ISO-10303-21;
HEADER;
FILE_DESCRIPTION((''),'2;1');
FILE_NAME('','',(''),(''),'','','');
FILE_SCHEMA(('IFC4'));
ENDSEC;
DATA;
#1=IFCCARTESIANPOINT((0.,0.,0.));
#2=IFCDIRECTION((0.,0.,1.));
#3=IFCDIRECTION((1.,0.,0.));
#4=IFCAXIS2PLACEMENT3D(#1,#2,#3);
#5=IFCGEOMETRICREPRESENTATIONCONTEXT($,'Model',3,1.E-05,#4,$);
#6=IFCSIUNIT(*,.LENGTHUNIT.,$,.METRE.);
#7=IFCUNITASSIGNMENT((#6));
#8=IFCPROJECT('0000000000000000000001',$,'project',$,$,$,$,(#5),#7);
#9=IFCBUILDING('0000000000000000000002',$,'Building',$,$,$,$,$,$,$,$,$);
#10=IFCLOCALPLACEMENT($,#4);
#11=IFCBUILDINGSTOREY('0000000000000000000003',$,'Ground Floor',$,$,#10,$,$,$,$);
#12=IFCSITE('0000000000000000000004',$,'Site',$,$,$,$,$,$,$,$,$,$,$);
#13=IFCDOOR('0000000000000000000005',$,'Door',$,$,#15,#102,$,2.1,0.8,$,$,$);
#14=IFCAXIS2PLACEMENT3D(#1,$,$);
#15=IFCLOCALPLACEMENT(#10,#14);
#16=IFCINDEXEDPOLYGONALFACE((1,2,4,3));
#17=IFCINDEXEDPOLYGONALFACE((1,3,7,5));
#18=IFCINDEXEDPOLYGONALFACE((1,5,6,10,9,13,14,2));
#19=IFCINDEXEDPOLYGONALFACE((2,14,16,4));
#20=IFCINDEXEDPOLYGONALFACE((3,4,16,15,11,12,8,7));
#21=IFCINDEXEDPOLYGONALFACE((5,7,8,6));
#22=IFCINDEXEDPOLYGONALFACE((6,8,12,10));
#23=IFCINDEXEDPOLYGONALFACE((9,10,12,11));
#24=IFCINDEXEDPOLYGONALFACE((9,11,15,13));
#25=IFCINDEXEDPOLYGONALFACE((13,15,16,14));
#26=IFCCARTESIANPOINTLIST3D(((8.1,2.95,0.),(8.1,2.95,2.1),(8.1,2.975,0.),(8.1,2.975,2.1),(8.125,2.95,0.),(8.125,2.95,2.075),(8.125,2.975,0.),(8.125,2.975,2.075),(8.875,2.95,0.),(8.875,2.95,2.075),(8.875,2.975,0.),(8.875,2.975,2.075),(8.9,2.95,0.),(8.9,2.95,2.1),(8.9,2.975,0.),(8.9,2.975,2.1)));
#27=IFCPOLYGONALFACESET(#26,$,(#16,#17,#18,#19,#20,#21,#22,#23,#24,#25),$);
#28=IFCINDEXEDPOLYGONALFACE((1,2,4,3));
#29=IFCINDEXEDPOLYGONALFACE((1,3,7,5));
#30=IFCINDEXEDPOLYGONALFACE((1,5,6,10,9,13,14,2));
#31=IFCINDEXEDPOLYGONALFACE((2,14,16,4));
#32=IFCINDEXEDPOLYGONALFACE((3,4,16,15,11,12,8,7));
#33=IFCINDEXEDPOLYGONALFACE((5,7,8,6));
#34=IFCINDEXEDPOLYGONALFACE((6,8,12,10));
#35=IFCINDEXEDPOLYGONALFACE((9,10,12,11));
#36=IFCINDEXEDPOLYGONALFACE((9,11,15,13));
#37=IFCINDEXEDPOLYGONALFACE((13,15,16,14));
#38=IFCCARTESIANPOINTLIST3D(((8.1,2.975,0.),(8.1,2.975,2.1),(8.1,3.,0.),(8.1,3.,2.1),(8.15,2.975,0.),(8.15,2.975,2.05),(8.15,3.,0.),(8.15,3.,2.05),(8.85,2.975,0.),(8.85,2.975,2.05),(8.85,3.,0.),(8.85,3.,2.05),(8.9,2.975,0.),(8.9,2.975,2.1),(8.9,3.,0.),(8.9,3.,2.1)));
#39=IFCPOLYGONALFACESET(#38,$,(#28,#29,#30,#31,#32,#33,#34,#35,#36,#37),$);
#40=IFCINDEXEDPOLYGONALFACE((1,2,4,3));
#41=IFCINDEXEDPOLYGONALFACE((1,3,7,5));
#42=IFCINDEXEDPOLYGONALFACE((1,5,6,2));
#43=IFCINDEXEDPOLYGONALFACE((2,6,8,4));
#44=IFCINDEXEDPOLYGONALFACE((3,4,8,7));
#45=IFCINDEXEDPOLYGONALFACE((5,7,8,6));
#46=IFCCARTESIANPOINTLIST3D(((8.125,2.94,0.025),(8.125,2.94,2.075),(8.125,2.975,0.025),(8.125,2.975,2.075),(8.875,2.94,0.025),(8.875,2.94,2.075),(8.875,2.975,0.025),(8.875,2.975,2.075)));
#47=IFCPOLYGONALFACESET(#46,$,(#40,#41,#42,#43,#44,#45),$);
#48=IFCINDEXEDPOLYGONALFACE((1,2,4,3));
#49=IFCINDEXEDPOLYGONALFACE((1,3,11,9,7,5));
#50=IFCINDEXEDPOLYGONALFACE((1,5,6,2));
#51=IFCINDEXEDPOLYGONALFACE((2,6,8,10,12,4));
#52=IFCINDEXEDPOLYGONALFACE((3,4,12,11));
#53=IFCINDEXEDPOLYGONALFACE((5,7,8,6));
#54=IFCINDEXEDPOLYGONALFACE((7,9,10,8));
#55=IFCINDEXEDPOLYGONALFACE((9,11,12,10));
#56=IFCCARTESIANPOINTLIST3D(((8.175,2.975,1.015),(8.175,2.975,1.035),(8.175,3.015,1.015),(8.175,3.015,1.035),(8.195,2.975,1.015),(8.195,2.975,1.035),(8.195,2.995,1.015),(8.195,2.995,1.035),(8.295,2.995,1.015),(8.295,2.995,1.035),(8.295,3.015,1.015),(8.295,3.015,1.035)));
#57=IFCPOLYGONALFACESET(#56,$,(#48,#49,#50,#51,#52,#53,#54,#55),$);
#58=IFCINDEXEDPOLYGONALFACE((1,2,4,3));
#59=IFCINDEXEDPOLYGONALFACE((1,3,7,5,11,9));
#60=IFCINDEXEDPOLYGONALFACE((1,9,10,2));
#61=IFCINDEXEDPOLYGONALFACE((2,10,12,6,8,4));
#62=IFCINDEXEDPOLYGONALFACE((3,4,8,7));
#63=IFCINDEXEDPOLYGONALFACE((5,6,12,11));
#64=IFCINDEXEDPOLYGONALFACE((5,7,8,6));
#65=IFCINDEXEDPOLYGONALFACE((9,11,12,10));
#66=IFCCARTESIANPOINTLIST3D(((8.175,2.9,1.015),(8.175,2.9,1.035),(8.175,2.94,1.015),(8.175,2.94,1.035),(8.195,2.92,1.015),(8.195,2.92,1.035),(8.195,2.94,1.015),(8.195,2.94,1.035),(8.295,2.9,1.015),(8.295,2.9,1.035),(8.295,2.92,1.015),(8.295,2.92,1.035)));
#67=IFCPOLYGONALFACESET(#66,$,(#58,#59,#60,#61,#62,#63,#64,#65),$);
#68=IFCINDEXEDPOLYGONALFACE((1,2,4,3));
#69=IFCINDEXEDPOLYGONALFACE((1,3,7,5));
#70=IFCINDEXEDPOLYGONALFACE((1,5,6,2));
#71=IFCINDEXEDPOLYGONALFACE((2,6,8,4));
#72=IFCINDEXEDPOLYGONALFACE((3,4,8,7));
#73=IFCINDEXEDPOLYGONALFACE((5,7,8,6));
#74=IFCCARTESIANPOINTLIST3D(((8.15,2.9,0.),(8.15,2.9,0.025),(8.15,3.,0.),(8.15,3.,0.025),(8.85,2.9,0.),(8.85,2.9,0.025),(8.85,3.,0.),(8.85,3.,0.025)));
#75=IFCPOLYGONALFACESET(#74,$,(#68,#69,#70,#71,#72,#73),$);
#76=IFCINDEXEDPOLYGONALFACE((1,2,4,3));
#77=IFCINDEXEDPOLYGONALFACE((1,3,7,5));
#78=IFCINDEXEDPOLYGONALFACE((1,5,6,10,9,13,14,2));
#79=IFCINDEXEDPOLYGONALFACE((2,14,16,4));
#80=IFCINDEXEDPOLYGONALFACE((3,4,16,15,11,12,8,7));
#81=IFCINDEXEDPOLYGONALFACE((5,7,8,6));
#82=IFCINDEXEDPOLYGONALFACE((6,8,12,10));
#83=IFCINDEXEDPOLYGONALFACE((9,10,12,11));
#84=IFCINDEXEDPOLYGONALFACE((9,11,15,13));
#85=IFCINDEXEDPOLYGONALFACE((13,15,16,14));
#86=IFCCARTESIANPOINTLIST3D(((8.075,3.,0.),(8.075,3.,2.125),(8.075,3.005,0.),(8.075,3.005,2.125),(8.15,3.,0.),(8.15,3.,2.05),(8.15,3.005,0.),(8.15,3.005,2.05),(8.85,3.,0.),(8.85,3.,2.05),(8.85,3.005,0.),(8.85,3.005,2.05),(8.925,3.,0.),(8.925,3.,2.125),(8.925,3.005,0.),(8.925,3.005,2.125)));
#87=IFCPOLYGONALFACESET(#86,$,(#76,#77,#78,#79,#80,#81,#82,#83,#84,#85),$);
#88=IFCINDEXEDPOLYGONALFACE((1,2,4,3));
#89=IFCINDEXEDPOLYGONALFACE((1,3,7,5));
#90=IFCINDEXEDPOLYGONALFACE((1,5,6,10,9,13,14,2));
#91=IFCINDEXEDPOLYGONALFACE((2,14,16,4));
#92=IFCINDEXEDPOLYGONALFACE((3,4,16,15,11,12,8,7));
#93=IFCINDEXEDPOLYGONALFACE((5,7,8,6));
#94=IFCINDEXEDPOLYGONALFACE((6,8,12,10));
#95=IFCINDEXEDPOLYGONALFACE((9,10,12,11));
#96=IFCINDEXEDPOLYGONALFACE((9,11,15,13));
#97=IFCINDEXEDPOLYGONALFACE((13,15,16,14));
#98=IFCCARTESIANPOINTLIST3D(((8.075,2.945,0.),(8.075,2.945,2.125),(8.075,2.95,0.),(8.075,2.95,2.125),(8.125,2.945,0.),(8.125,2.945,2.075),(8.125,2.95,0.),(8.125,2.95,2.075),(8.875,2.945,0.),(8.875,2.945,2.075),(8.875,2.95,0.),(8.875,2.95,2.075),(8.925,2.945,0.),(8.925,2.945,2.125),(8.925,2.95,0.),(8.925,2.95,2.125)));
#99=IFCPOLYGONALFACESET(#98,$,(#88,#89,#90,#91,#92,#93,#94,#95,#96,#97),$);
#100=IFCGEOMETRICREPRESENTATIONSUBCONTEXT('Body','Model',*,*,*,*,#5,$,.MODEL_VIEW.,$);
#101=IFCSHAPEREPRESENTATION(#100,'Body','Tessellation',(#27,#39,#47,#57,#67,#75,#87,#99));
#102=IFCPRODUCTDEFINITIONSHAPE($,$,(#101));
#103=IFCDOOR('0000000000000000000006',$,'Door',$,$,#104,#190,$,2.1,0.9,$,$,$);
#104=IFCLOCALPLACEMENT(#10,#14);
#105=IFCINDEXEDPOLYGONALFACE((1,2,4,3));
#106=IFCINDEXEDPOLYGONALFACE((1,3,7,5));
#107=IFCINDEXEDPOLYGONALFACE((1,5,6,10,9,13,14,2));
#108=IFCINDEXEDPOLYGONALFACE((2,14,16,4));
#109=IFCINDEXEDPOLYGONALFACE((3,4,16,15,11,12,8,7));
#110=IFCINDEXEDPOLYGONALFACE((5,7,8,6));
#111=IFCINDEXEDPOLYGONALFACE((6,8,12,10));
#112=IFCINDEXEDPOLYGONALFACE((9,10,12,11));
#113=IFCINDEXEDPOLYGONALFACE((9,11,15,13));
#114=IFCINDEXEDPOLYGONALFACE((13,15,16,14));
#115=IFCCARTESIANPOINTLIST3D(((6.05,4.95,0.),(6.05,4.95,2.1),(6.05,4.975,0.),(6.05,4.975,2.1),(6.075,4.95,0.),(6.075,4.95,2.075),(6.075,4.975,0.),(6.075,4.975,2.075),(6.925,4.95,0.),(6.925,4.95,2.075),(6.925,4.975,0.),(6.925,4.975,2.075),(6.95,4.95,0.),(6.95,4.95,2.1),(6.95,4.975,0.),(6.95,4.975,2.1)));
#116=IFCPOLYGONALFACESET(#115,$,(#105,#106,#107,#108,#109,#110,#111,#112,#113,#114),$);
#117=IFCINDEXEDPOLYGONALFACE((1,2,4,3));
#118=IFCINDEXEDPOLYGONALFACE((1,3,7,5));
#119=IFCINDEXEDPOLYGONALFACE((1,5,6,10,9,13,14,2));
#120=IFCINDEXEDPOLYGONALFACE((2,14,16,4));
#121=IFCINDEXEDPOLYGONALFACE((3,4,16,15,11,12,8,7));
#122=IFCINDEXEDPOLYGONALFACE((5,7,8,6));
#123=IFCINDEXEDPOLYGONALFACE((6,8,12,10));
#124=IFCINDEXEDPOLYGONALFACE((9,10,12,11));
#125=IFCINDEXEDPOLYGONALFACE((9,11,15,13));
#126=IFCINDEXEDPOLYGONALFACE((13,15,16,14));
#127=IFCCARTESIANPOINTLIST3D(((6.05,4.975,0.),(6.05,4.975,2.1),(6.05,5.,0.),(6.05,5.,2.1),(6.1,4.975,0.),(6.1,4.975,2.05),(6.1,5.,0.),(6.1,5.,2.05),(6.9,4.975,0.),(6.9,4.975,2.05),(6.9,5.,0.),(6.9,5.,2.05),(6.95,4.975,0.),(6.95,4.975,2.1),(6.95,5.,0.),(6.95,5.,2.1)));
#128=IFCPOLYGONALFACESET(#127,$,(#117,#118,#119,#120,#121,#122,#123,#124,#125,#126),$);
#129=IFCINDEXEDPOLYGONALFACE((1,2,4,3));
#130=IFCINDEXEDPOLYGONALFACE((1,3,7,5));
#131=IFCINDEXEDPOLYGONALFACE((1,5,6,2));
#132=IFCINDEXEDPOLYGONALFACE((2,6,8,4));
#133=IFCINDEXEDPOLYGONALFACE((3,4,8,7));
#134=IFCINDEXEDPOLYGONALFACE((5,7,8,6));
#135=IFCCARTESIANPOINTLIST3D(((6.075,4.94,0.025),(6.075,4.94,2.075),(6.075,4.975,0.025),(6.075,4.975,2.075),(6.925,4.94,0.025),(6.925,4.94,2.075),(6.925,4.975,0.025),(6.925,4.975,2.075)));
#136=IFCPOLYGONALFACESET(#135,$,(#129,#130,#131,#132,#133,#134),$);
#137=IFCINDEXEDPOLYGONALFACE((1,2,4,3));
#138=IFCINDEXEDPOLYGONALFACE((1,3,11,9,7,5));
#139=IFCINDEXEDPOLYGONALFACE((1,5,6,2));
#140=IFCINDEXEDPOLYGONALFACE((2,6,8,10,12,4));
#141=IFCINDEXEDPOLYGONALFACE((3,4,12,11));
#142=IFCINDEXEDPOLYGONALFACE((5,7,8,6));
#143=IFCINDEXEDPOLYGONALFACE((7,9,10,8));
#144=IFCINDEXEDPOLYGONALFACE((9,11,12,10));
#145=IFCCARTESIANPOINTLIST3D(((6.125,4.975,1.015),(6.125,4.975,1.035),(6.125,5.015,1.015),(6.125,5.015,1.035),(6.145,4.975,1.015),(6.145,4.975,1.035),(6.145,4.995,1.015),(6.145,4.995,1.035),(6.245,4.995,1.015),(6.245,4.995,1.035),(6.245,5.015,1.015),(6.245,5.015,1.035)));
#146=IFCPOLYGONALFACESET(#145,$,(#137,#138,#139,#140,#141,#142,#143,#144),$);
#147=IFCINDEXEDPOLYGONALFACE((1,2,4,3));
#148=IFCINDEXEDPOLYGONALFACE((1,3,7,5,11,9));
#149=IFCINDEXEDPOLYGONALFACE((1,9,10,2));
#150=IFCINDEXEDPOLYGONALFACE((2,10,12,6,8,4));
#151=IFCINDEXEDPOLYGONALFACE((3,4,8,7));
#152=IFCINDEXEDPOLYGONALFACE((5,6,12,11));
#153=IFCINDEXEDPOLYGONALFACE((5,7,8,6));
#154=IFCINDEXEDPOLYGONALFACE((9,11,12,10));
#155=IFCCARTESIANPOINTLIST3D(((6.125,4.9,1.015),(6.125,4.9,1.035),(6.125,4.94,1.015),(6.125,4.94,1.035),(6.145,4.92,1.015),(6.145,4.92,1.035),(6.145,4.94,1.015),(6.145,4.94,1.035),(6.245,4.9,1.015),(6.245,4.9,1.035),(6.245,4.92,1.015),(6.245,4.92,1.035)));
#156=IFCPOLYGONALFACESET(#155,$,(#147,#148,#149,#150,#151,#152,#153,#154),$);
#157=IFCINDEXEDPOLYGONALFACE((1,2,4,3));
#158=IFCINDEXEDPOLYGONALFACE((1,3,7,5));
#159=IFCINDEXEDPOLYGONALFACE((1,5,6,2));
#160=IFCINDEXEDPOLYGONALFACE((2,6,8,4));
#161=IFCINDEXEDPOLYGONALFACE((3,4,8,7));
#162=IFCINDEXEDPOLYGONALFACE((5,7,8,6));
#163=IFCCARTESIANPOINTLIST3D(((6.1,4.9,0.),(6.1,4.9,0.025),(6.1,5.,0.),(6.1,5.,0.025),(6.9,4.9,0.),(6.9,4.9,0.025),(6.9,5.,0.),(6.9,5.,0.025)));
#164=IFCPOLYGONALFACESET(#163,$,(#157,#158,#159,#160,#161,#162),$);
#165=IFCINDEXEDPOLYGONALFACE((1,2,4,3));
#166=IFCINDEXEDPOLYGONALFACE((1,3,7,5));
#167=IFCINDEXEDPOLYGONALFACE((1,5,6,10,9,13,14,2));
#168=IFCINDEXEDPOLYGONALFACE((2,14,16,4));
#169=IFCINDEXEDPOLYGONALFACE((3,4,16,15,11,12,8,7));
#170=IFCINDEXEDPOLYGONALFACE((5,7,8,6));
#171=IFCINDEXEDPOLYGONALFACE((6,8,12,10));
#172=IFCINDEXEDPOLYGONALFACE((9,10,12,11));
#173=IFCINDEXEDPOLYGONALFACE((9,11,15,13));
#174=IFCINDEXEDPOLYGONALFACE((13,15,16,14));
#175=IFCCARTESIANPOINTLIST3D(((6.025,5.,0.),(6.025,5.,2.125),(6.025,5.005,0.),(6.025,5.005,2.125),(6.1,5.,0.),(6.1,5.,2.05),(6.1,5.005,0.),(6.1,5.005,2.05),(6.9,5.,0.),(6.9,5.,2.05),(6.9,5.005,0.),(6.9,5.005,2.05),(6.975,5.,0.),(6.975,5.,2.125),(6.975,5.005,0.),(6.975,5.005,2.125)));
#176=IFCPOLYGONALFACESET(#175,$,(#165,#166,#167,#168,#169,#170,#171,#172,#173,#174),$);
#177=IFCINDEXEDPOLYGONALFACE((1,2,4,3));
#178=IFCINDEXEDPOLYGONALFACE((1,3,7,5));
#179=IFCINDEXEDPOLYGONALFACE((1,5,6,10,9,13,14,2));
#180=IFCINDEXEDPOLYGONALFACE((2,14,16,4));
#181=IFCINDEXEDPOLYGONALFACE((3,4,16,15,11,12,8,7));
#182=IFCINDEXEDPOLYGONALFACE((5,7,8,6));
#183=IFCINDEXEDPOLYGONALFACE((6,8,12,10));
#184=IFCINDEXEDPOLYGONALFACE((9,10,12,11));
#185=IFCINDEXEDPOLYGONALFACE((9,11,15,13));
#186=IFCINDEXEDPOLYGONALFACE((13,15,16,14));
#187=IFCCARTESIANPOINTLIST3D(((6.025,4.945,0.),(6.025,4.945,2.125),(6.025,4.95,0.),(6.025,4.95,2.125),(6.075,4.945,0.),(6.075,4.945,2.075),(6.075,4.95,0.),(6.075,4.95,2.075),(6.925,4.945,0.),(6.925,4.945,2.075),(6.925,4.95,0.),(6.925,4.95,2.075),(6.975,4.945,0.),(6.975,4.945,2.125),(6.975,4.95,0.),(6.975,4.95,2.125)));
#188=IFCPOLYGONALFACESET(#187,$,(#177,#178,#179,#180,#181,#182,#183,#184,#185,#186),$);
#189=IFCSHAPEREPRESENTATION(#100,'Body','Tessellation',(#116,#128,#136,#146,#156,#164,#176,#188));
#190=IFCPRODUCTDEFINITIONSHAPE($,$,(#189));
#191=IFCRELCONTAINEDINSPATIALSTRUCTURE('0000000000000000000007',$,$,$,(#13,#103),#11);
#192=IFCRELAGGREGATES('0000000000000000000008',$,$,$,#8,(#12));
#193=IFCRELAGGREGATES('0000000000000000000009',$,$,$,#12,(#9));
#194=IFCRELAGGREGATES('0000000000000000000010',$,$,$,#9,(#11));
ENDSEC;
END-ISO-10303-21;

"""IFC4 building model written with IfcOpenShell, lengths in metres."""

from ifc_helpers import new_model, si_unit, frame, origin_with_axes, place, context, subcontext, project, spatial, line, indexed_curve, outline, extrude, element, save


model = new_model("IFC4")

# Units and contexts
model_context = context("Model", 3, precision=1e-05, world=origin_with_axes())
body_context = subcontext(model_context, "Body", "Model", "MODEL_VIEW")
ifc_project = project(units=[si_unit("LENGTHUNIT", "METRE")], contexts=[model_context])

# Site, building, storey
site = spatial("IfcSite", under=ifc_project, Name="Site")
building = spatial("IfcBuilding", under=site, Name="Building")
storey_placement = place(None, origin_with_axes())
storey = spatial("IfcBuildingStorey", under=building, at=storey_placement, Name="Ground Floor")

# Doors
door_1_placement = place(storey_placement, frame((8.9, 3.0, 0.0), z_axis=(0.0, 0.0, 1.0), x_axis=(-1.0, 0.0, 0.0)))
element("IfcDoor", 1, at=door_1_placement, inside=storey, Name="Door", OverallHeight=2.1, OverallWidth=0.8, context=body_context, shape_type="SweptSolid", body=[
    extrude(outline(indexed_curve([(0.0, 0.0), (0.0, 2.1), (0.8, 2.1), (0.8, 0.0), (0.775, 0.0), (0.775, 2.075), (0.025, 2.075), (0.025, 0.0)], segments=[line(1, 2, 3, 4, 5, 6, 7, 8, 1)])), frame((0.0, 0.025, 0.0), z_axis=(0.0, -1.0, 0.0), x_axis=(1.0, 0.0, 0.0)), (0.0, 0.0, -1.0), 0.025),
    extrude(outline(indexed_curve([(0.0, 0.0), (0.0, 2.1), (0.8, 2.1), (0.8, 0.0), (0.75, 0.0), (0.75, 2.05), (0.05, 2.05), (0.05, 0.0)], segments=[line(1, 2, 3, 4, 5, 6, 7, 8, 1)])), frame((0.0, 0.0, 0.0), z_axis=(0.0, -1.0, 0.0), x_axis=(1.0, 0.0, 0.0)), (0.0, 0.0, -1.0), 0.025),
    extrude(outline(indexed_curve([(0.0, 0.0), (0.75, 0.0), (0.75, 0.035), (0.0, 0.035)], segments=[line(1, 2, 3, 4, 1)])), frame((0.025, 0.025, 0.025), z_axis=(0.0, 0.0, 1.0), x_axis=(1.0, 0.0, 0.0)), (0.0, 0.0, 1.0), 2.05),
    extrude(outline(indexed_curve([(0.0, 0.0), (0.0, -0.04), (-0.12, -0.04), (-0.12, -0.02), (-0.02, -0.02), (-0.02, 0.0)], segments=[line(1, 2, 3, 4, 5, 6, 1)])), frame((0.725, 0.025, 1.015), z_axis=(0.0, 0.0, 1.0), x_axis=(1.0, 0.0, 0.0)), (0.0, 0.0, 1.0), 0.02),
    extrude(outline(indexed_curve([(0.0, 0.0), (0.0, 0.04), (-0.12, 0.04), (-0.12, 0.02), (-0.02, 0.02), (-0.02, 0.0)], segments=[line(1, 2, 3, 4, 5, 6, 1)])), frame((0.725, 0.06, 1.015), z_axis=(0.0, 0.0, 1.0), x_axis=(1.0, 0.0, 0.0)), (0.0, 0.0, 1.0), 0.02),
    extrude(outline(indexed_curve([(0.0, 0.0), (0.7, 0.0), (0.7, 0.1), (0.0, 0.1)], segments=[line(1, 2, 3, 4, 1)])), frame((0.05, 0.0, 0.0), z_axis=(0.0, 0.0, 1.0), x_axis=(1.0, 0.0, 0.0)), (0.0, 0.0, 1.0), 0.025),
    extrude(outline(indexed_curve([(0.0, 0.0), (0.0, 2.125), (0.85, 2.125), (0.85, 0.0), (0.775, 0.0), (0.775, 2.05), (0.075, 2.05), (0.075, 0.0)], segments=[line(1, 2, 3, 4, 5, 6, 7, 8, 1)])), frame((-0.025, -0.005, 0.0), z_axis=(0.0, -1.0, 0.0), x_axis=(1.0, 0.0, 0.0)), (0.0, 0.0, -1.0), 0.005),
    extrude(outline(indexed_curve([(0.0, 0.0), (0.0, 2.125), (0.85, 2.125), (0.85, 0.0), (0.8, 0.0), (0.8, 2.075), (0.05, 2.075), (0.05, 0.0)], segments=[line(1, 2, 3, 4, 5, 6, 7, 8, 1)])), frame((-0.025, 0.05, 0.0), z_axis=(0.0, -1.0, 0.0), x_axis=(1.0, 0.0, 0.0)), (0.0, 0.0, -1.0), 0.005),
])
door_2_placement = place(storey_placement, frame((6.95, 5.0, 0.0), z_axis=(0.0, 0.0, 1.0), x_axis=(-1.0, 0.0, 0.0)))
element("IfcDoor", 2, at=door_2_placement, inside=storey, Name="Door", OverallHeight=2.1, OverallWidth=0.9, context=body_context, shape_type="SweptSolid", body=[
    extrude(outline(indexed_curve([(0.0, 0.0), (0.0, 2.1), (0.9, 2.1), (0.9, 0.0), (0.875, 0.0), (0.875, 2.075), (0.025, 2.075), (0.025, 0.0)], segments=[line(1, 2, 3, 4, 5, 6, 7, 8, 1)])), frame((0.0, 0.025, 0.0), z_axis=(0.0, -1.0, 0.0), x_axis=(1.0, 0.0, 0.0)), (0.0, 0.0, -1.0), 0.025),
    extrude(outline(indexed_curve([(0.0, 0.0), (0.0, 2.1), (0.9, 2.1), (0.9, 0.0), (0.85, 0.0), (0.85, 2.05), (0.05, 2.05), (0.05, 0.0)], segments=[line(1, 2, 3, 4, 5, 6, 7, 8, 1)])), frame((0.0, 0.0, 0.0), z_axis=(0.0, -1.0, 0.0), x_axis=(1.0, 0.0, 0.0)), (0.0, 0.0, -1.0), 0.025),
    extrude(outline(indexed_curve([(0.0, 0.0), (0.85, 0.0), (0.85, 0.035), (0.0, 0.035)], segments=[line(1, 2, 3, 4, 1)])), frame((0.025, 0.025, 0.025), z_axis=(0.0, 0.0, 1.0), x_axis=(1.0, 0.0, 0.0)), (0.0, 0.0, 1.0), 2.05),
    extrude(outline(indexed_curve([(0.0, 0.0), (0.0, -0.04), (-0.12, -0.04), (-0.12, -0.02), (-0.02, -0.02), (-0.02, 0.0)], segments=[line(1, 2, 3, 4, 5, 6, 1)])), frame((0.825, 0.025, 1.015), z_axis=(0.0, 0.0, 1.0), x_axis=(1.0, 0.0, 0.0)), (0.0, 0.0, 1.0), 0.02),
    extrude(outline(indexed_curve([(0.0, 0.0), (0.0, 0.04), (-0.12, 0.04), (-0.12, 0.02), (-0.02, 0.02), (-0.02, 0.0)], segments=[line(1, 2, 3, 4, 5, 6, 1)])), frame((0.825, 0.06, 1.015), z_axis=(0.0, 0.0, 1.0), x_axis=(1.0, 0.0, 0.0)), (0.0, 0.0, 1.0), 0.02),
    extrude(outline(indexed_curve([(0.0, 0.0), (0.8, 0.0), (0.8, 0.1), (0.0, 0.1)], segments=[line(1, 2, 3, 4, 1)])), frame((0.05, 0.0, 0.0), z_axis=(0.0, 0.0, 1.0), x_axis=(1.0, 0.0, 0.0)), (0.0, 0.0, 1.0), 0.025),
    extrude(outline(indexed_curve([(0.0, 0.0), (0.0, 2.125), (0.95, 2.125), (0.95, 0.0), (0.875, 0.0), (0.875, 2.05), (0.075, 2.05), (0.075, 0.0)], segments=[line(1, 2, 3, 4, 5, 6, 7, 8, 1)])), frame((-0.025, -0.005, 0.0), z_axis=(0.0, -1.0, 0.0), x_axis=(1.0, 0.0, 0.0)), (0.0, 0.0, -1.0), 0.005),
    extrude(outline(indexed_curve([(0.0, 0.0), (0.0, 2.125), (0.95, 2.125), (0.95, 0.0), (0.9, 0.0), (0.9, 2.075), (0.05, 2.075), (0.05, 0.0)], segments=[line(1, 2, 3, 4, 5, 6, 7, 8, 1)])), frame((-0.025, 0.05, 0.0), z_axis=(0.0, -1.0, 0.0), x_axis=(1.0, 0.0, 0.0)), (0.0, 0.0, -1.0), 0.005),
])

save(model, "model.ifc")
